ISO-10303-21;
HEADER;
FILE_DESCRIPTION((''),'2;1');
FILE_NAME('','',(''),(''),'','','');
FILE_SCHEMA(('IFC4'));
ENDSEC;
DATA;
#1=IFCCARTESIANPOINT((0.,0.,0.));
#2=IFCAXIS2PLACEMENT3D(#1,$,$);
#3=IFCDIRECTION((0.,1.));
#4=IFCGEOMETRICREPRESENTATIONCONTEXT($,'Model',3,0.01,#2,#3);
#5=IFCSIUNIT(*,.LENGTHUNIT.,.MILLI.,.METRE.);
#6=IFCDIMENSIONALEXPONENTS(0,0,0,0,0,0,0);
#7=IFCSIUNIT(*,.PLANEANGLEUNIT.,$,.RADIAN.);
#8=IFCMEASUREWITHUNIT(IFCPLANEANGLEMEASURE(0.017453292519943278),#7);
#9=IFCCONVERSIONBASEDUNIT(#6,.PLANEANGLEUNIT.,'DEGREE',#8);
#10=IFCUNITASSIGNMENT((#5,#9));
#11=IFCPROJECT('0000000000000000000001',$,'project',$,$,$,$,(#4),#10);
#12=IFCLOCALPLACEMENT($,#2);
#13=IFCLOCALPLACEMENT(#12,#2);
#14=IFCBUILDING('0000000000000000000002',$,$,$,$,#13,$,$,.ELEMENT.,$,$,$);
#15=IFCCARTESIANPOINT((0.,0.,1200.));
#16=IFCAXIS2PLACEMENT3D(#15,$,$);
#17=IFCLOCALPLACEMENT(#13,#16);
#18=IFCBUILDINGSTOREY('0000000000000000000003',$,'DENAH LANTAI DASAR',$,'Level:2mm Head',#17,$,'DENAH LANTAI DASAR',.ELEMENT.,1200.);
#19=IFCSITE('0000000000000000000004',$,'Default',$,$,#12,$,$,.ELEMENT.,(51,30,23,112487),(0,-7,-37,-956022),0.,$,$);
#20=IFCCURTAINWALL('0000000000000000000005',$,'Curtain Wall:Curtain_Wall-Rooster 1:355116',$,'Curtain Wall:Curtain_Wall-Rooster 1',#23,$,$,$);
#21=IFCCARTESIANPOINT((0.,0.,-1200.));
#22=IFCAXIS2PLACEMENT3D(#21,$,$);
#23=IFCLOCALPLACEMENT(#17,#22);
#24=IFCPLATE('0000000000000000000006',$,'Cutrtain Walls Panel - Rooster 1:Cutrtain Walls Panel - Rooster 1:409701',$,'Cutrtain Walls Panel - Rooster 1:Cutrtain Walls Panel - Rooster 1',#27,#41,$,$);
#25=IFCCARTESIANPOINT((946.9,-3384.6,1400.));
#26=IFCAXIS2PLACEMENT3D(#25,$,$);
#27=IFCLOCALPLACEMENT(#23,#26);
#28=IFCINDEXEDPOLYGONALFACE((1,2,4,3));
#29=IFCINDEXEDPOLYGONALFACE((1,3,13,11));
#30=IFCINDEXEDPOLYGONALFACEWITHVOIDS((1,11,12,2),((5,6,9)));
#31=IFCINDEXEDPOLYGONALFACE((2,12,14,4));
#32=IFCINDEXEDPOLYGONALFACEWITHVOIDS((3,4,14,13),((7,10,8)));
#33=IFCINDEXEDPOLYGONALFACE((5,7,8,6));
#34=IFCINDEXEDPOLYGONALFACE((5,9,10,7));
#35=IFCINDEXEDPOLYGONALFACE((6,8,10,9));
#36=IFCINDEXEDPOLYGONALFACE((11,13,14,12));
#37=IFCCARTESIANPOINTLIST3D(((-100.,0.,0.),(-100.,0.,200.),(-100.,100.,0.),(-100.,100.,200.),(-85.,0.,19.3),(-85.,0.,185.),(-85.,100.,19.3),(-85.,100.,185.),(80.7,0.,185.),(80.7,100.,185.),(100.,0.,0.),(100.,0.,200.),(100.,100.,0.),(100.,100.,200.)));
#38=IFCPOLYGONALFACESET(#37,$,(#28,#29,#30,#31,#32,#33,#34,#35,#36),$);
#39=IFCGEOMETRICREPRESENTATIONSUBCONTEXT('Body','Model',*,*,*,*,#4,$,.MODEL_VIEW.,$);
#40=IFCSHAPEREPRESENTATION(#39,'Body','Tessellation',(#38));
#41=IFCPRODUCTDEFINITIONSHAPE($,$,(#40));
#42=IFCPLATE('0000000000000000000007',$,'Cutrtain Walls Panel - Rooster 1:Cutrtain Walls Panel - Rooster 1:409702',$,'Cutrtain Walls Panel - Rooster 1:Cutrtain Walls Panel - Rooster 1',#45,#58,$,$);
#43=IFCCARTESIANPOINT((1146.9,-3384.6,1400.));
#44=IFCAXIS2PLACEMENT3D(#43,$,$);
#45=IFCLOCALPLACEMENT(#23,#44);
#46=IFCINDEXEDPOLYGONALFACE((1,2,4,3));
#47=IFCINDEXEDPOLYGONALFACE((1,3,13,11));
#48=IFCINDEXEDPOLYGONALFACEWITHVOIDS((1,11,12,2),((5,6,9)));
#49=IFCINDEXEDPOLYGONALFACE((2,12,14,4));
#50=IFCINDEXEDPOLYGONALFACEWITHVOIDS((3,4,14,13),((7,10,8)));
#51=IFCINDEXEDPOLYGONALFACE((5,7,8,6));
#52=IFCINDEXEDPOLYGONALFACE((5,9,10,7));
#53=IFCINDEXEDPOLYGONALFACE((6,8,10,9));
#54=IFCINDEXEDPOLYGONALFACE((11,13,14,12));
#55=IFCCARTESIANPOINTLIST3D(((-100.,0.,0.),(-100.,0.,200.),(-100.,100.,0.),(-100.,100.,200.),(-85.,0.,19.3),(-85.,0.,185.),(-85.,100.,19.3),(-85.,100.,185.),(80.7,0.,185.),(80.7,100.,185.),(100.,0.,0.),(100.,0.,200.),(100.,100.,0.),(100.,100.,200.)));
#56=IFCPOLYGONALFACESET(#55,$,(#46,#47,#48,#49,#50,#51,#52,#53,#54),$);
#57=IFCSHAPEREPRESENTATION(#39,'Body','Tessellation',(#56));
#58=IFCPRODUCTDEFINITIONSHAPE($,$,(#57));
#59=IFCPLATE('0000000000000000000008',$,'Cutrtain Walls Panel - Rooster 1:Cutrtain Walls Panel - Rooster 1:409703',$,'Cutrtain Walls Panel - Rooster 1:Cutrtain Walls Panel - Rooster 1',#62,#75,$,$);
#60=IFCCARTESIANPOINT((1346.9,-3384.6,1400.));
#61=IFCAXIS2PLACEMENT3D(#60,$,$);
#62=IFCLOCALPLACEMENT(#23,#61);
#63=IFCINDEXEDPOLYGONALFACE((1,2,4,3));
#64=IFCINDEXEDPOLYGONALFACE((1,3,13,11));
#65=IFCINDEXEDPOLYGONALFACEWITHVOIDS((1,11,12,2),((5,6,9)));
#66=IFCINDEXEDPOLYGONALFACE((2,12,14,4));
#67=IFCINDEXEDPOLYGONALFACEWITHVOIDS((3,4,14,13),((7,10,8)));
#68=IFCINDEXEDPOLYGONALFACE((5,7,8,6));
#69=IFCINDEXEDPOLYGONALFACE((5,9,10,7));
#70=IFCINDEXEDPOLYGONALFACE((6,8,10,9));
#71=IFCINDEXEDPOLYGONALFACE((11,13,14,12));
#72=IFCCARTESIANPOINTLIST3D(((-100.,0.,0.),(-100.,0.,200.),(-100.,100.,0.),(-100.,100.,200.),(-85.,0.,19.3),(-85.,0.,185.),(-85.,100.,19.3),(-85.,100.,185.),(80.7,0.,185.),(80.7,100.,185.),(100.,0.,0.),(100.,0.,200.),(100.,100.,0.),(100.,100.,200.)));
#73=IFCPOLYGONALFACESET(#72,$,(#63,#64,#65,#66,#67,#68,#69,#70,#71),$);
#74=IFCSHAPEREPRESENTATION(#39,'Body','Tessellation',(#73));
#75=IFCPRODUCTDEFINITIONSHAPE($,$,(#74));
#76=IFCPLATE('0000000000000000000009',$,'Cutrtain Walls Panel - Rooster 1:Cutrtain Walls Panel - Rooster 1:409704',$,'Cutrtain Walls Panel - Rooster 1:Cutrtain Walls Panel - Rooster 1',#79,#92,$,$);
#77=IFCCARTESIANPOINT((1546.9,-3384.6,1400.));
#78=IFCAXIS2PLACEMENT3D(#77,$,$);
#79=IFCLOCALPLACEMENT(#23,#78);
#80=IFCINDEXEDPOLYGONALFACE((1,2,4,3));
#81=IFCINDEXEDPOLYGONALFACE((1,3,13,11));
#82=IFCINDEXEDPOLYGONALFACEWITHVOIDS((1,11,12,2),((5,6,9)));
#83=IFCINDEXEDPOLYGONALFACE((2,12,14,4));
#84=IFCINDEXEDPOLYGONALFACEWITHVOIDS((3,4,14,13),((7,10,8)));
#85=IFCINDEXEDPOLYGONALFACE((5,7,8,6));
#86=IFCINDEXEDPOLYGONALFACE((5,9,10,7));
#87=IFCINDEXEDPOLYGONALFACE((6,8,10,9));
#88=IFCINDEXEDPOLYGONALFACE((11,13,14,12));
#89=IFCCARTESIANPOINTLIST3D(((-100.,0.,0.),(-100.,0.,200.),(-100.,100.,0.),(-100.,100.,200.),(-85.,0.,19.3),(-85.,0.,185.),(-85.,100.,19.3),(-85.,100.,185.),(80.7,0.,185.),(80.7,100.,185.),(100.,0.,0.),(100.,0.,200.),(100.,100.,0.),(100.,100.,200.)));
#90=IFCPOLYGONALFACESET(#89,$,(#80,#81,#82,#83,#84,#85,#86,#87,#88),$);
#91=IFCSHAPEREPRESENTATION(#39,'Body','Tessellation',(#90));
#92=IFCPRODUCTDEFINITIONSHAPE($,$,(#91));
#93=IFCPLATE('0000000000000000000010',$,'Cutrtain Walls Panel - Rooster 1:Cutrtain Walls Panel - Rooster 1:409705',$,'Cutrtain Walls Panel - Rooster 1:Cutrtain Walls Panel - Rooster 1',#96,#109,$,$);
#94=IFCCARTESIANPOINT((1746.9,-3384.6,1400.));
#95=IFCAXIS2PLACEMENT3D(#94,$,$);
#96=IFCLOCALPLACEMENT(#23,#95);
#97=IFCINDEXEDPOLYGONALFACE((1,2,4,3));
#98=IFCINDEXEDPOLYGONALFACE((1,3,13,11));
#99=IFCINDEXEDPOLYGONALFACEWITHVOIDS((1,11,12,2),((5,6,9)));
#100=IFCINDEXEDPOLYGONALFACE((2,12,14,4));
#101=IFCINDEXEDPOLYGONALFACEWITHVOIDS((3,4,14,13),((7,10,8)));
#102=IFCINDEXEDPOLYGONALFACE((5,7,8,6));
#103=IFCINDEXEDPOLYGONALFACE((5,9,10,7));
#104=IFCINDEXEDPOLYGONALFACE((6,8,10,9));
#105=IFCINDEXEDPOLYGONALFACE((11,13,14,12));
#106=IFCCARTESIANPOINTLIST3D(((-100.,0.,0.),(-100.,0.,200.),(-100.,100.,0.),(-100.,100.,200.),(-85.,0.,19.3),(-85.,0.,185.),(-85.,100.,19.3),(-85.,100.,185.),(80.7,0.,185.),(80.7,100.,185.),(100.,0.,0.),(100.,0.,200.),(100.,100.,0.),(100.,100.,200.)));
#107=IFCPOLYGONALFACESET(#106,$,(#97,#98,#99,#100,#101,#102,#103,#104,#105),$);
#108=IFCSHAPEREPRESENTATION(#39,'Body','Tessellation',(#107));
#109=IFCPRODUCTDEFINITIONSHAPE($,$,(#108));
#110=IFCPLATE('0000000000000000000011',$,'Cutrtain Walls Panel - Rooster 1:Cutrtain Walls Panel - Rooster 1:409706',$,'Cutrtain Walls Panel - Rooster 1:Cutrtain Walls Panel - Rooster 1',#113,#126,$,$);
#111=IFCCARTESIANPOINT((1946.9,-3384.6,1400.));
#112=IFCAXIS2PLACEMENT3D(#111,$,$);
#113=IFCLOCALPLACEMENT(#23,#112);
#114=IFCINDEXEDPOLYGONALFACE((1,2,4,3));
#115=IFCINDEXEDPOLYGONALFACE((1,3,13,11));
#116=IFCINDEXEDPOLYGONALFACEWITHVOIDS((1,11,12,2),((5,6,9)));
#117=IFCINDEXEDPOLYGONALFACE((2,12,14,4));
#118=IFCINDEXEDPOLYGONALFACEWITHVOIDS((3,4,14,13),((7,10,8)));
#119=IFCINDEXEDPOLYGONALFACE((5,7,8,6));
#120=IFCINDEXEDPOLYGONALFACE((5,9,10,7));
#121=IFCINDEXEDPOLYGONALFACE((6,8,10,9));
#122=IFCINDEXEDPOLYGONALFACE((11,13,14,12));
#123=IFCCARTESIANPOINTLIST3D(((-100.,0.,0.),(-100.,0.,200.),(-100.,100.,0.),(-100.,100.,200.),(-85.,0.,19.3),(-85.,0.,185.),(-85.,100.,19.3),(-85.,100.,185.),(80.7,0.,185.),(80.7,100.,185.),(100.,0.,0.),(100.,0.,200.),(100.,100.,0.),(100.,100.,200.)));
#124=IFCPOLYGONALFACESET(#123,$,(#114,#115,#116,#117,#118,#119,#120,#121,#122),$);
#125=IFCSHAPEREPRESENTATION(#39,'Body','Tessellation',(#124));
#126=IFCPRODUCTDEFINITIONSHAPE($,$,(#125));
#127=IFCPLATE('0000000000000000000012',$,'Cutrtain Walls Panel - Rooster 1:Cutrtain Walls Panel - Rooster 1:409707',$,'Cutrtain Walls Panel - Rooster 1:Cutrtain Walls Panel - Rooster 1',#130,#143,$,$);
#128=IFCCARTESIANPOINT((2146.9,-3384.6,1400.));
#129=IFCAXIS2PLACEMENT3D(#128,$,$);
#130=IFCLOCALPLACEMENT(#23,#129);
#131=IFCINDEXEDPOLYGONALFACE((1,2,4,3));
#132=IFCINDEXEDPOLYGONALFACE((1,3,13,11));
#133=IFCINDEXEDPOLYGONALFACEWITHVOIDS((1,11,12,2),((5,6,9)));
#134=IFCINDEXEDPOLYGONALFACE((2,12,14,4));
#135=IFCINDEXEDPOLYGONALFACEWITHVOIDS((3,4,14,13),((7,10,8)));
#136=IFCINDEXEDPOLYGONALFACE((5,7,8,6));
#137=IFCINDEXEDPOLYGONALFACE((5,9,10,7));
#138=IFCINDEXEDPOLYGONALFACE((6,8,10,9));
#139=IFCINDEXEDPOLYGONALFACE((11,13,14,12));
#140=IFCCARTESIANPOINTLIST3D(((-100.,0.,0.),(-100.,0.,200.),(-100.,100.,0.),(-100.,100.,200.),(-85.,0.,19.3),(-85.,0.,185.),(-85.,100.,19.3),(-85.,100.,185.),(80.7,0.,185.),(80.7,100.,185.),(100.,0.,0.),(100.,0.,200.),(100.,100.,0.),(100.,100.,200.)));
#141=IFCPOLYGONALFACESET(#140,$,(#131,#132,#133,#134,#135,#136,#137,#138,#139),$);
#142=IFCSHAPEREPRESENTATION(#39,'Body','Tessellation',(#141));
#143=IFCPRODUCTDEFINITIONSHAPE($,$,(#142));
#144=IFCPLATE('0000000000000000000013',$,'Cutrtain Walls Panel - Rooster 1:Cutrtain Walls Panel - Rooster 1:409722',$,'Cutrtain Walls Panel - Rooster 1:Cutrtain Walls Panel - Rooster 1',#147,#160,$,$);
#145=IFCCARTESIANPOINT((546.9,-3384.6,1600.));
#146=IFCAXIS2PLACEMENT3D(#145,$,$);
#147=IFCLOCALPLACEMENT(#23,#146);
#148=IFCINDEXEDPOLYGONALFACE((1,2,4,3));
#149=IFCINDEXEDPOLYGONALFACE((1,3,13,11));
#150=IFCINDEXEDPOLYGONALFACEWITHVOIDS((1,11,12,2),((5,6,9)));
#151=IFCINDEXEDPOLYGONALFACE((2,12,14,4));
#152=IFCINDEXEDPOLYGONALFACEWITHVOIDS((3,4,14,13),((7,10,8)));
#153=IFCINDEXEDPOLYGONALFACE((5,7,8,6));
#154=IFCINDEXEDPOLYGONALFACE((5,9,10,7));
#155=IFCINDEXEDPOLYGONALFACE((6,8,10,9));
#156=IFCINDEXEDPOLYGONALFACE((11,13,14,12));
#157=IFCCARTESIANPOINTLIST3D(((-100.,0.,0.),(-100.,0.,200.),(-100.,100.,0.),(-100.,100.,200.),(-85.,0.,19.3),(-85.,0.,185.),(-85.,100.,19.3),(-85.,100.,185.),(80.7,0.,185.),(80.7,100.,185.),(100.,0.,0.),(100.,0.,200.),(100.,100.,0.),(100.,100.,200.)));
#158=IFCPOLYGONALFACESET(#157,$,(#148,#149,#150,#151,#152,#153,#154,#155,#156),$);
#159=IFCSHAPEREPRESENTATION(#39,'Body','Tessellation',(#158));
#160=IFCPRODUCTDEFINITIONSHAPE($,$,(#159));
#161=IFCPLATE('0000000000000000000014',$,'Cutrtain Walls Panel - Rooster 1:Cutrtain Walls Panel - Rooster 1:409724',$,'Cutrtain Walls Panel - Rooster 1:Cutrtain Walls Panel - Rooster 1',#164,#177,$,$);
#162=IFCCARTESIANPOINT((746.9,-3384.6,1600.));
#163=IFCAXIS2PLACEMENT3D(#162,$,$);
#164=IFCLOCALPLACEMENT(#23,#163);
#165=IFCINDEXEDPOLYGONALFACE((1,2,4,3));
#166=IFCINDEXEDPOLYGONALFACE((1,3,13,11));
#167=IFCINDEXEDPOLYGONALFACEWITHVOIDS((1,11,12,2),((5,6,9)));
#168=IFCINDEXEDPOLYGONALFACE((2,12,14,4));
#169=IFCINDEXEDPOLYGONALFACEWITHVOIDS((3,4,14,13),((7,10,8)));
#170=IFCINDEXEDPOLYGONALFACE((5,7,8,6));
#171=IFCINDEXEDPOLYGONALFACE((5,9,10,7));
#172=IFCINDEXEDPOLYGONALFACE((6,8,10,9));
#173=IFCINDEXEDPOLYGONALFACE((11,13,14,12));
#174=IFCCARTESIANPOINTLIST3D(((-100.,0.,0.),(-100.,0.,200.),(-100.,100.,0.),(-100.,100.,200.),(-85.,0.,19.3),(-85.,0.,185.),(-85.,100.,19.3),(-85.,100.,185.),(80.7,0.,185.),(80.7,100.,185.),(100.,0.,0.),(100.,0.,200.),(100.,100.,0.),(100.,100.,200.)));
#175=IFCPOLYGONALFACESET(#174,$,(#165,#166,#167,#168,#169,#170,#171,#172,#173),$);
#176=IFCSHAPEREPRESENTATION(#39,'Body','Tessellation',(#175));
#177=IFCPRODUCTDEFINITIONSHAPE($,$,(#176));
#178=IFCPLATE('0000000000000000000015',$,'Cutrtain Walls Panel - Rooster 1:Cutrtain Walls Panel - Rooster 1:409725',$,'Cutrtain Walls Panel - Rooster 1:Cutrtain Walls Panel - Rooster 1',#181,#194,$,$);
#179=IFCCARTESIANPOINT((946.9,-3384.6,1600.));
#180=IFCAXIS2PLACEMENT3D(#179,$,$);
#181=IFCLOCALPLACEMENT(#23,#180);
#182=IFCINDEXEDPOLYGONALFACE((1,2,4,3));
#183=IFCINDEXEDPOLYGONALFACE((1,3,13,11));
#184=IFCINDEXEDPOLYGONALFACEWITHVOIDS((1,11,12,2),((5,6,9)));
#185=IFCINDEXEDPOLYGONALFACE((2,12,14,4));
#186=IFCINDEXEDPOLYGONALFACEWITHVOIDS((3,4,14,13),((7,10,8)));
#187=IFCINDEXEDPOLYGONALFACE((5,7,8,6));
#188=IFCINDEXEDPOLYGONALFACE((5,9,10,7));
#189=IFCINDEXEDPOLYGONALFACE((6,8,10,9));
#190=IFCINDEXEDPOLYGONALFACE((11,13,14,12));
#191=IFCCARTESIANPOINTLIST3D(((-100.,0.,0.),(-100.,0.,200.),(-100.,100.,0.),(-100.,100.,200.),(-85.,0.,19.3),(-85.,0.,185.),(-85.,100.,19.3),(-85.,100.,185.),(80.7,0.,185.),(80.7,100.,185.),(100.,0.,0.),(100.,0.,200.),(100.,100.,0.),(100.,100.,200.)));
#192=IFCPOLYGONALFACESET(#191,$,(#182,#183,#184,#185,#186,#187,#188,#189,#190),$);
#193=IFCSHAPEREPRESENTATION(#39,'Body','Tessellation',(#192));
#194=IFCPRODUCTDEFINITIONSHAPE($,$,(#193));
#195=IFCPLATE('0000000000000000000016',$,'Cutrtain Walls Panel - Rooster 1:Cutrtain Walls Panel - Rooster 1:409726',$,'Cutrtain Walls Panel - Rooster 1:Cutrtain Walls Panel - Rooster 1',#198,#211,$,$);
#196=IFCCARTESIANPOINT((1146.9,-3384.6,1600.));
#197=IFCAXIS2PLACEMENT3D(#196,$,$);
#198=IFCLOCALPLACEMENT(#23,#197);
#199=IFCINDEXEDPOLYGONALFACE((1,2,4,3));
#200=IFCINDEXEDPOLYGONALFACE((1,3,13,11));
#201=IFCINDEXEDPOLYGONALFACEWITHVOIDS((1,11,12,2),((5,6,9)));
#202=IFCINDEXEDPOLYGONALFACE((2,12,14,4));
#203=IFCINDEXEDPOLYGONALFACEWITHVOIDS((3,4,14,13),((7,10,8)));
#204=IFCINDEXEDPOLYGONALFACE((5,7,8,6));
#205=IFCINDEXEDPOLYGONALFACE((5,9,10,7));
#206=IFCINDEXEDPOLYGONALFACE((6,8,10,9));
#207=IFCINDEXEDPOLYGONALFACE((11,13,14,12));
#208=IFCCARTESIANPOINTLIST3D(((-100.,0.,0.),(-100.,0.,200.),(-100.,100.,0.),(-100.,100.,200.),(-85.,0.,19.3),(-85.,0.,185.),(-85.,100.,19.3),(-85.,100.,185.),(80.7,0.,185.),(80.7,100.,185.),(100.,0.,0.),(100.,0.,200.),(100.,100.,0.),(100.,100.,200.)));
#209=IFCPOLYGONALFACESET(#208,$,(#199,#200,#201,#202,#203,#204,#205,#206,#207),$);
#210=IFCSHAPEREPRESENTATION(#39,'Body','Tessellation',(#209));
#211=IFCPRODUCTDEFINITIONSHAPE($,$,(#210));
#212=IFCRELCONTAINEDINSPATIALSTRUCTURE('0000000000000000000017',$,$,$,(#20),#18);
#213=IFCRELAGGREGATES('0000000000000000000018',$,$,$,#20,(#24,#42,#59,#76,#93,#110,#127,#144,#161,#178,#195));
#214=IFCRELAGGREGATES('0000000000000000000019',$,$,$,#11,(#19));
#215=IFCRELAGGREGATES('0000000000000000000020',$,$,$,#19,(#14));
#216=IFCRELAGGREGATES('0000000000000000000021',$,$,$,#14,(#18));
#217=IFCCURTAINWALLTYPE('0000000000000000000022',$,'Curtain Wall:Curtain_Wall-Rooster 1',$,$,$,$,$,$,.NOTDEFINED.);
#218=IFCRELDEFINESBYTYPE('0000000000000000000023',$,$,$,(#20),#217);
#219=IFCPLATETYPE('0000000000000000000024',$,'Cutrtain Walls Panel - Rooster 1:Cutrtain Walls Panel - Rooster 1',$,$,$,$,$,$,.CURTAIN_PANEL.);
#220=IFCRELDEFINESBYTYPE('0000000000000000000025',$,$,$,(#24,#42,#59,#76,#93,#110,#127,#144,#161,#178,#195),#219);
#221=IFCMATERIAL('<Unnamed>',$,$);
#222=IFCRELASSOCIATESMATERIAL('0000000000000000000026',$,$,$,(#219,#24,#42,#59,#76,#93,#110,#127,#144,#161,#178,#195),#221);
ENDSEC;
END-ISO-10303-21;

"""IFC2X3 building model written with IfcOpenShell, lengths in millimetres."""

from ifc_helpers import new_model, entity, si_unit, converted_unit, direction, frame, origin, place, context, subcontext, project, spatial, polyline, outline, extrude, source, transform, mapped, material, type_object, type_shapes, element, aggregate, save


model = new_model("IFC2X3")

# Units and contexts
model_context = context("Model", 3, precision=0.01, world=origin(), true_north=direction((0.0, 1.0)))
body_context = subcontext(model_context, "Body", "Model", "MODEL_VIEW")
ifc_project = project(units=[si_unit("LENGTHUNIT", "METRE", prefix="MILLI"), converted_unit("PLANEANGLEUNIT", "DEGREE", entity("IfcPlaneAngleMeasure", 0.017453292519943278), si_unit("PLANEANGLEUNIT", "RADIAN"), dimensions=[0, 0, 0, 0, 0, 0, 0])], contexts=[model_context])

# Site, building, storey
site_placement = place(None, origin())
site = spatial("IfcSite", under=ifc_project, at=site_placement, Name="Default", CompositionType="ELEMENT", RefLatitude=(51, 30, 23, 112487), RefLongitude=(0, -7, -37, -956022), RefElevation=0.0)
building_placement = place(site_placement, origin())
building = spatial("IfcBuilding", under=site, at=building_placement, CompositionType="ELEMENT")
storey_placement = place(building_placement, frame((0.0, 0.0, 1200.0)))
storey = spatial("IfcBuildingStorey", under=building, at=storey_placement, Name="DENAH LANTAI DASAR", ObjectType="Level:2mm Head", LongName="DENAH LANTAI DASAR", CompositionType="ELEMENT", Elevation=1200.0)

# Curtain wall, plates
curtain_wall_type = type_object("IfcCurtainWallType", Name="Curtain Wall:Curtain_Wall-Rooster 1", PredefinedType="NOTDEFINED")
curtain_wall_1_placement = place(storey_placement, frame((0.0, 0.0, -1200.0)))
curtain_wall_1 = element("IfcCurtainWall", 1, at=curtain_wall_1_placement, inside=storey, type_object=curtain_wall_type, Name="Curtain Wall:Curtain_Wall-Rooster 1:355116", ObjectType="Curtain Wall:Curtain_Wall-Rooster 1")
ifc_material_1 = material(Name="<Unnamed>")
plate_type = type_object("IfcPlateType", Name="Cutrtain Walls Panel - Rooster 1:Cutrtain Walls Panel - Rooster 1", PredefinedType="CURTAIN_PANEL", material=ifc_material_1)
shared_shape = source(origin(), body_context, "Body", "SweptSolid", [
    extrude(outline(polyline([(-100.0, -100.0), (100.0, -100.0), (100.0, 100.0), (-100.0, 100.0), (-100.0, -100.0)]), holes=[polyline([(80.7, 85.0), (-85.0, -80.7), (-85.0, 85.0), (80.7, 85.0)])]), frame((0.0, 0.0, 100.0), z_axis=(0.0, 1.0, 0.0), x_axis=(0.0, 0.0, -1.0)), (0.0, 0.0, 1.0), 100.0),
])
type_shapes(plate_type, [shared_shape])
plate_1_placement = place(curtain_wall_1_placement, frame((946.9, -3384.6, 1400.0)))
plate_1 = element("IfcPlate", 2, at=plate_1_placement, type_object=plate_type, material=ifc_material_1, Name="Cutrtain Walls Panel - Rooster 1:Cutrtain Walls Panel - Rooster 1:409701", ObjectType="Cutrtain Walls Panel - Rooster 1:Cutrtain Walls Panel - Rooster 1", context=body_context, shape_type="MappedRepresentation", body=[
    mapped(shared_shape, transform((0.0, 0.0, 0.0), scale=1.0)),
])
plate_2_placement = place(curtain_wall_1_placement, frame((1146.9, -3384.6, 1400.0)))
plate_2 = element("IfcPlate", 3, at=plate_2_placement, type_object=plate_type, material=ifc_material_1, Name="Cutrtain Walls Panel - Rooster 1:Cutrtain Walls Panel - Rooster 1:409702", ObjectType="Cutrtain Walls Panel - Rooster 1:Cutrtain Walls Panel - Rooster 1", context=body_context, shape_type="MappedRepresentation", body=[
    mapped(shared_shape, transform((0.0, 0.0, 0.0), scale=1.0)),
])
plate_3_placement = place(curtain_wall_1_placement, frame((1346.9, -3384.6, 1400.0)))
plate_3 = element("IfcPlate", 4, at=plate_3_placement, type_object=plate_type, material=ifc_material_1, Name="Cutrtain Walls Panel - Rooster 1:Cutrtain Walls Panel - Rooster 1:409703", ObjectType="Cutrtain Walls Panel - Rooster 1:Cutrtain Walls Panel - Rooster 1", context=body_context, shape_type="MappedRepresentation", body=[
    mapped(shared_shape, transform((0.0, 0.0, 0.0), scale=1.0)),
])
plate_4_placement = place(curtain_wall_1_placement, frame((1546.9, -3384.6, 1400.0)))
plate_4 = element("IfcPlate", 5, at=plate_4_placement, type_object=plate_type, material=ifc_material_1, Name="Cutrtain Walls Panel - Rooster 1:Cutrtain Walls Panel - Rooster 1:409704", ObjectType="Cutrtain Walls Panel - Rooster 1:Cutrtain Walls Panel - Rooster 1", context=body_context, shape_type="MappedRepresentation", body=[
    mapped(shared_shape, transform((0.0, 0.0, 0.0), scale=1.0)),
])
plate_5_placement = place(curtain_wall_1_placement, frame((1746.9, -3384.6, 1400.0)))
plate_5 = element("IfcPlate", 6, at=plate_5_placement, type_object=plate_type, material=ifc_material_1, Name="Cutrtain Walls Panel - Rooster 1:Cutrtain Walls Panel - Rooster 1:409705", ObjectType="Cutrtain Walls Panel - Rooster 1:Cutrtain Walls Panel - Rooster 1", context=body_context, shape_type="MappedRepresentation", body=[
    mapped(shared_shape, transform((0.0, 0.0, 0.0), scale=1.0)),
])
plate_6_placement = place(curtain_wall_1_placement, frame((1946.9, -3384.6, 1400.0)))
plate_6 = element("IfcPlate", 7, at=plate_6_placement, type_object=plate_type, material=ifc_material_1, Name="Cutrtain Walls Panel - Rooster 1:Cutrtain Walls Panel - Rooster 1:409706", ObjectType="Cutrtain Walls Panel - Rooster 1:Cutrtain Walls Panel - Rooster 1", context=body_context, shape_type="MappedRepresentation", body=[
    mapped(shared_shape, transform((0.0, 0.0, 0.0), scale=1.0)),
])
plate_7_placement = place(curtain_wall_1_placement, frame((2146.9, -3384.6, 1400.0)))
plate_7 = element("IfcPlate", 8, at=plate_7_placement, type_object=plate_type, material=ifc_material_1, Name="Cutrtain Walls Panel - Rooster 1:Cutrtain Walls Panel - Rooster 1:409707", ObjectType="Cutrtain Walls Panel - Rooster 1:Cutrtain Walls Panel - Rooster 1", context=body_context, shape_type="MappedRepresentation", body=[
    mapped(shared_shape, transform((0.0, 0.0, 0.0), scale=1.0)),
])
plate_8_placement = place(curtain_wall_1_placement, frame((546.9, -3384.6, 1600.0)))
plate_8 = element("IfcPlate", 9, at=plate_8_placement, type_object=plate_type, material=ifc_material_1, Name="Cutrtain Walls Panel - Rooster 1:Cutrtain Walls Panel - Rooster 1:409722", ObjectType="Cutrtain Walls Panel - Rooster 1:Cutrtain Walls Panel - Rooster 1", context=body_context, shape_type="MappedRepresentation", body=[
    mapped(shared_shape, transform((0.0, 0.0, 0.0), scale=1.0)),
])
plate_9_placement = place(curtain_wall_1_placement, frame((746.9, -3384.6, 1600.0)))
plate_9 = element("IfcPlate", 10, at=plate_9_placement, type_object=plate_type, material=ifc_material_1, Name="Cutrtain Walls Panel - Rooster 1:Cutrtain Walls Panel - Rooster 1:409724", ObjectType="Cutrtain Walls Panel - Rooster 1:Cutrtain Walls Panel - Rooster 1", context=body_context, shape_type="MappedRepresentation", body=[
    mapped(shared_shape, transform((0.0, 0.0, 0.0), scale=1.0)),
])
plate_10_placement = place(curtain_wall_1_placement, frame((946.9, -3384.6, 1600.0)))
plate_10 = element("IfcPlate", 11, at=plate_10_placement, type_object=plate_type, material=ifc_material_1, Name="Cutrtain Walls Panel - Rooster 1:Cutrtain Walls Panel - Rooster 1:409725", ObjectType="Cutrtain Walls Panel - Rooster 1:Cutrtain Walls Panel - Rooster 1", context=body_context, shape_type="MappedRepresentation", body=[
    mapped(shared_shape, transform((0.0, 0.0, 0.0), scale=1.0)),
])
plate_11_placement = place(curtain_wall_1_placement, frame((1146.9, -3384.6, 1600.0)))
plate_11 = element("IfcPlate", 12, at=plate_11_placement, type_object=plate_type, material=ifc_material_1, Name="Cutrtain Walls Panel - Rooster 1:Cutrtain Walls Panel - Rooster 1:409726", ObjectType="Cutrtain Walls Panel - Rooster 1:Cutrtain Walls Panel - Rooster 1", context=body_context, shape_type="MappedRepresentation", body=[
    mapped(shared_shape, transform((0.0, 0.0, 0.0), scale=1.0)),
])
aggregate(curtain_wall_1, [plate_1, plate_2, plate_3, plate_4, plate_5, plate_6, plate_7, plate_8, plate_9, plate_10, plate_11])

save(model, "model.ifc")
